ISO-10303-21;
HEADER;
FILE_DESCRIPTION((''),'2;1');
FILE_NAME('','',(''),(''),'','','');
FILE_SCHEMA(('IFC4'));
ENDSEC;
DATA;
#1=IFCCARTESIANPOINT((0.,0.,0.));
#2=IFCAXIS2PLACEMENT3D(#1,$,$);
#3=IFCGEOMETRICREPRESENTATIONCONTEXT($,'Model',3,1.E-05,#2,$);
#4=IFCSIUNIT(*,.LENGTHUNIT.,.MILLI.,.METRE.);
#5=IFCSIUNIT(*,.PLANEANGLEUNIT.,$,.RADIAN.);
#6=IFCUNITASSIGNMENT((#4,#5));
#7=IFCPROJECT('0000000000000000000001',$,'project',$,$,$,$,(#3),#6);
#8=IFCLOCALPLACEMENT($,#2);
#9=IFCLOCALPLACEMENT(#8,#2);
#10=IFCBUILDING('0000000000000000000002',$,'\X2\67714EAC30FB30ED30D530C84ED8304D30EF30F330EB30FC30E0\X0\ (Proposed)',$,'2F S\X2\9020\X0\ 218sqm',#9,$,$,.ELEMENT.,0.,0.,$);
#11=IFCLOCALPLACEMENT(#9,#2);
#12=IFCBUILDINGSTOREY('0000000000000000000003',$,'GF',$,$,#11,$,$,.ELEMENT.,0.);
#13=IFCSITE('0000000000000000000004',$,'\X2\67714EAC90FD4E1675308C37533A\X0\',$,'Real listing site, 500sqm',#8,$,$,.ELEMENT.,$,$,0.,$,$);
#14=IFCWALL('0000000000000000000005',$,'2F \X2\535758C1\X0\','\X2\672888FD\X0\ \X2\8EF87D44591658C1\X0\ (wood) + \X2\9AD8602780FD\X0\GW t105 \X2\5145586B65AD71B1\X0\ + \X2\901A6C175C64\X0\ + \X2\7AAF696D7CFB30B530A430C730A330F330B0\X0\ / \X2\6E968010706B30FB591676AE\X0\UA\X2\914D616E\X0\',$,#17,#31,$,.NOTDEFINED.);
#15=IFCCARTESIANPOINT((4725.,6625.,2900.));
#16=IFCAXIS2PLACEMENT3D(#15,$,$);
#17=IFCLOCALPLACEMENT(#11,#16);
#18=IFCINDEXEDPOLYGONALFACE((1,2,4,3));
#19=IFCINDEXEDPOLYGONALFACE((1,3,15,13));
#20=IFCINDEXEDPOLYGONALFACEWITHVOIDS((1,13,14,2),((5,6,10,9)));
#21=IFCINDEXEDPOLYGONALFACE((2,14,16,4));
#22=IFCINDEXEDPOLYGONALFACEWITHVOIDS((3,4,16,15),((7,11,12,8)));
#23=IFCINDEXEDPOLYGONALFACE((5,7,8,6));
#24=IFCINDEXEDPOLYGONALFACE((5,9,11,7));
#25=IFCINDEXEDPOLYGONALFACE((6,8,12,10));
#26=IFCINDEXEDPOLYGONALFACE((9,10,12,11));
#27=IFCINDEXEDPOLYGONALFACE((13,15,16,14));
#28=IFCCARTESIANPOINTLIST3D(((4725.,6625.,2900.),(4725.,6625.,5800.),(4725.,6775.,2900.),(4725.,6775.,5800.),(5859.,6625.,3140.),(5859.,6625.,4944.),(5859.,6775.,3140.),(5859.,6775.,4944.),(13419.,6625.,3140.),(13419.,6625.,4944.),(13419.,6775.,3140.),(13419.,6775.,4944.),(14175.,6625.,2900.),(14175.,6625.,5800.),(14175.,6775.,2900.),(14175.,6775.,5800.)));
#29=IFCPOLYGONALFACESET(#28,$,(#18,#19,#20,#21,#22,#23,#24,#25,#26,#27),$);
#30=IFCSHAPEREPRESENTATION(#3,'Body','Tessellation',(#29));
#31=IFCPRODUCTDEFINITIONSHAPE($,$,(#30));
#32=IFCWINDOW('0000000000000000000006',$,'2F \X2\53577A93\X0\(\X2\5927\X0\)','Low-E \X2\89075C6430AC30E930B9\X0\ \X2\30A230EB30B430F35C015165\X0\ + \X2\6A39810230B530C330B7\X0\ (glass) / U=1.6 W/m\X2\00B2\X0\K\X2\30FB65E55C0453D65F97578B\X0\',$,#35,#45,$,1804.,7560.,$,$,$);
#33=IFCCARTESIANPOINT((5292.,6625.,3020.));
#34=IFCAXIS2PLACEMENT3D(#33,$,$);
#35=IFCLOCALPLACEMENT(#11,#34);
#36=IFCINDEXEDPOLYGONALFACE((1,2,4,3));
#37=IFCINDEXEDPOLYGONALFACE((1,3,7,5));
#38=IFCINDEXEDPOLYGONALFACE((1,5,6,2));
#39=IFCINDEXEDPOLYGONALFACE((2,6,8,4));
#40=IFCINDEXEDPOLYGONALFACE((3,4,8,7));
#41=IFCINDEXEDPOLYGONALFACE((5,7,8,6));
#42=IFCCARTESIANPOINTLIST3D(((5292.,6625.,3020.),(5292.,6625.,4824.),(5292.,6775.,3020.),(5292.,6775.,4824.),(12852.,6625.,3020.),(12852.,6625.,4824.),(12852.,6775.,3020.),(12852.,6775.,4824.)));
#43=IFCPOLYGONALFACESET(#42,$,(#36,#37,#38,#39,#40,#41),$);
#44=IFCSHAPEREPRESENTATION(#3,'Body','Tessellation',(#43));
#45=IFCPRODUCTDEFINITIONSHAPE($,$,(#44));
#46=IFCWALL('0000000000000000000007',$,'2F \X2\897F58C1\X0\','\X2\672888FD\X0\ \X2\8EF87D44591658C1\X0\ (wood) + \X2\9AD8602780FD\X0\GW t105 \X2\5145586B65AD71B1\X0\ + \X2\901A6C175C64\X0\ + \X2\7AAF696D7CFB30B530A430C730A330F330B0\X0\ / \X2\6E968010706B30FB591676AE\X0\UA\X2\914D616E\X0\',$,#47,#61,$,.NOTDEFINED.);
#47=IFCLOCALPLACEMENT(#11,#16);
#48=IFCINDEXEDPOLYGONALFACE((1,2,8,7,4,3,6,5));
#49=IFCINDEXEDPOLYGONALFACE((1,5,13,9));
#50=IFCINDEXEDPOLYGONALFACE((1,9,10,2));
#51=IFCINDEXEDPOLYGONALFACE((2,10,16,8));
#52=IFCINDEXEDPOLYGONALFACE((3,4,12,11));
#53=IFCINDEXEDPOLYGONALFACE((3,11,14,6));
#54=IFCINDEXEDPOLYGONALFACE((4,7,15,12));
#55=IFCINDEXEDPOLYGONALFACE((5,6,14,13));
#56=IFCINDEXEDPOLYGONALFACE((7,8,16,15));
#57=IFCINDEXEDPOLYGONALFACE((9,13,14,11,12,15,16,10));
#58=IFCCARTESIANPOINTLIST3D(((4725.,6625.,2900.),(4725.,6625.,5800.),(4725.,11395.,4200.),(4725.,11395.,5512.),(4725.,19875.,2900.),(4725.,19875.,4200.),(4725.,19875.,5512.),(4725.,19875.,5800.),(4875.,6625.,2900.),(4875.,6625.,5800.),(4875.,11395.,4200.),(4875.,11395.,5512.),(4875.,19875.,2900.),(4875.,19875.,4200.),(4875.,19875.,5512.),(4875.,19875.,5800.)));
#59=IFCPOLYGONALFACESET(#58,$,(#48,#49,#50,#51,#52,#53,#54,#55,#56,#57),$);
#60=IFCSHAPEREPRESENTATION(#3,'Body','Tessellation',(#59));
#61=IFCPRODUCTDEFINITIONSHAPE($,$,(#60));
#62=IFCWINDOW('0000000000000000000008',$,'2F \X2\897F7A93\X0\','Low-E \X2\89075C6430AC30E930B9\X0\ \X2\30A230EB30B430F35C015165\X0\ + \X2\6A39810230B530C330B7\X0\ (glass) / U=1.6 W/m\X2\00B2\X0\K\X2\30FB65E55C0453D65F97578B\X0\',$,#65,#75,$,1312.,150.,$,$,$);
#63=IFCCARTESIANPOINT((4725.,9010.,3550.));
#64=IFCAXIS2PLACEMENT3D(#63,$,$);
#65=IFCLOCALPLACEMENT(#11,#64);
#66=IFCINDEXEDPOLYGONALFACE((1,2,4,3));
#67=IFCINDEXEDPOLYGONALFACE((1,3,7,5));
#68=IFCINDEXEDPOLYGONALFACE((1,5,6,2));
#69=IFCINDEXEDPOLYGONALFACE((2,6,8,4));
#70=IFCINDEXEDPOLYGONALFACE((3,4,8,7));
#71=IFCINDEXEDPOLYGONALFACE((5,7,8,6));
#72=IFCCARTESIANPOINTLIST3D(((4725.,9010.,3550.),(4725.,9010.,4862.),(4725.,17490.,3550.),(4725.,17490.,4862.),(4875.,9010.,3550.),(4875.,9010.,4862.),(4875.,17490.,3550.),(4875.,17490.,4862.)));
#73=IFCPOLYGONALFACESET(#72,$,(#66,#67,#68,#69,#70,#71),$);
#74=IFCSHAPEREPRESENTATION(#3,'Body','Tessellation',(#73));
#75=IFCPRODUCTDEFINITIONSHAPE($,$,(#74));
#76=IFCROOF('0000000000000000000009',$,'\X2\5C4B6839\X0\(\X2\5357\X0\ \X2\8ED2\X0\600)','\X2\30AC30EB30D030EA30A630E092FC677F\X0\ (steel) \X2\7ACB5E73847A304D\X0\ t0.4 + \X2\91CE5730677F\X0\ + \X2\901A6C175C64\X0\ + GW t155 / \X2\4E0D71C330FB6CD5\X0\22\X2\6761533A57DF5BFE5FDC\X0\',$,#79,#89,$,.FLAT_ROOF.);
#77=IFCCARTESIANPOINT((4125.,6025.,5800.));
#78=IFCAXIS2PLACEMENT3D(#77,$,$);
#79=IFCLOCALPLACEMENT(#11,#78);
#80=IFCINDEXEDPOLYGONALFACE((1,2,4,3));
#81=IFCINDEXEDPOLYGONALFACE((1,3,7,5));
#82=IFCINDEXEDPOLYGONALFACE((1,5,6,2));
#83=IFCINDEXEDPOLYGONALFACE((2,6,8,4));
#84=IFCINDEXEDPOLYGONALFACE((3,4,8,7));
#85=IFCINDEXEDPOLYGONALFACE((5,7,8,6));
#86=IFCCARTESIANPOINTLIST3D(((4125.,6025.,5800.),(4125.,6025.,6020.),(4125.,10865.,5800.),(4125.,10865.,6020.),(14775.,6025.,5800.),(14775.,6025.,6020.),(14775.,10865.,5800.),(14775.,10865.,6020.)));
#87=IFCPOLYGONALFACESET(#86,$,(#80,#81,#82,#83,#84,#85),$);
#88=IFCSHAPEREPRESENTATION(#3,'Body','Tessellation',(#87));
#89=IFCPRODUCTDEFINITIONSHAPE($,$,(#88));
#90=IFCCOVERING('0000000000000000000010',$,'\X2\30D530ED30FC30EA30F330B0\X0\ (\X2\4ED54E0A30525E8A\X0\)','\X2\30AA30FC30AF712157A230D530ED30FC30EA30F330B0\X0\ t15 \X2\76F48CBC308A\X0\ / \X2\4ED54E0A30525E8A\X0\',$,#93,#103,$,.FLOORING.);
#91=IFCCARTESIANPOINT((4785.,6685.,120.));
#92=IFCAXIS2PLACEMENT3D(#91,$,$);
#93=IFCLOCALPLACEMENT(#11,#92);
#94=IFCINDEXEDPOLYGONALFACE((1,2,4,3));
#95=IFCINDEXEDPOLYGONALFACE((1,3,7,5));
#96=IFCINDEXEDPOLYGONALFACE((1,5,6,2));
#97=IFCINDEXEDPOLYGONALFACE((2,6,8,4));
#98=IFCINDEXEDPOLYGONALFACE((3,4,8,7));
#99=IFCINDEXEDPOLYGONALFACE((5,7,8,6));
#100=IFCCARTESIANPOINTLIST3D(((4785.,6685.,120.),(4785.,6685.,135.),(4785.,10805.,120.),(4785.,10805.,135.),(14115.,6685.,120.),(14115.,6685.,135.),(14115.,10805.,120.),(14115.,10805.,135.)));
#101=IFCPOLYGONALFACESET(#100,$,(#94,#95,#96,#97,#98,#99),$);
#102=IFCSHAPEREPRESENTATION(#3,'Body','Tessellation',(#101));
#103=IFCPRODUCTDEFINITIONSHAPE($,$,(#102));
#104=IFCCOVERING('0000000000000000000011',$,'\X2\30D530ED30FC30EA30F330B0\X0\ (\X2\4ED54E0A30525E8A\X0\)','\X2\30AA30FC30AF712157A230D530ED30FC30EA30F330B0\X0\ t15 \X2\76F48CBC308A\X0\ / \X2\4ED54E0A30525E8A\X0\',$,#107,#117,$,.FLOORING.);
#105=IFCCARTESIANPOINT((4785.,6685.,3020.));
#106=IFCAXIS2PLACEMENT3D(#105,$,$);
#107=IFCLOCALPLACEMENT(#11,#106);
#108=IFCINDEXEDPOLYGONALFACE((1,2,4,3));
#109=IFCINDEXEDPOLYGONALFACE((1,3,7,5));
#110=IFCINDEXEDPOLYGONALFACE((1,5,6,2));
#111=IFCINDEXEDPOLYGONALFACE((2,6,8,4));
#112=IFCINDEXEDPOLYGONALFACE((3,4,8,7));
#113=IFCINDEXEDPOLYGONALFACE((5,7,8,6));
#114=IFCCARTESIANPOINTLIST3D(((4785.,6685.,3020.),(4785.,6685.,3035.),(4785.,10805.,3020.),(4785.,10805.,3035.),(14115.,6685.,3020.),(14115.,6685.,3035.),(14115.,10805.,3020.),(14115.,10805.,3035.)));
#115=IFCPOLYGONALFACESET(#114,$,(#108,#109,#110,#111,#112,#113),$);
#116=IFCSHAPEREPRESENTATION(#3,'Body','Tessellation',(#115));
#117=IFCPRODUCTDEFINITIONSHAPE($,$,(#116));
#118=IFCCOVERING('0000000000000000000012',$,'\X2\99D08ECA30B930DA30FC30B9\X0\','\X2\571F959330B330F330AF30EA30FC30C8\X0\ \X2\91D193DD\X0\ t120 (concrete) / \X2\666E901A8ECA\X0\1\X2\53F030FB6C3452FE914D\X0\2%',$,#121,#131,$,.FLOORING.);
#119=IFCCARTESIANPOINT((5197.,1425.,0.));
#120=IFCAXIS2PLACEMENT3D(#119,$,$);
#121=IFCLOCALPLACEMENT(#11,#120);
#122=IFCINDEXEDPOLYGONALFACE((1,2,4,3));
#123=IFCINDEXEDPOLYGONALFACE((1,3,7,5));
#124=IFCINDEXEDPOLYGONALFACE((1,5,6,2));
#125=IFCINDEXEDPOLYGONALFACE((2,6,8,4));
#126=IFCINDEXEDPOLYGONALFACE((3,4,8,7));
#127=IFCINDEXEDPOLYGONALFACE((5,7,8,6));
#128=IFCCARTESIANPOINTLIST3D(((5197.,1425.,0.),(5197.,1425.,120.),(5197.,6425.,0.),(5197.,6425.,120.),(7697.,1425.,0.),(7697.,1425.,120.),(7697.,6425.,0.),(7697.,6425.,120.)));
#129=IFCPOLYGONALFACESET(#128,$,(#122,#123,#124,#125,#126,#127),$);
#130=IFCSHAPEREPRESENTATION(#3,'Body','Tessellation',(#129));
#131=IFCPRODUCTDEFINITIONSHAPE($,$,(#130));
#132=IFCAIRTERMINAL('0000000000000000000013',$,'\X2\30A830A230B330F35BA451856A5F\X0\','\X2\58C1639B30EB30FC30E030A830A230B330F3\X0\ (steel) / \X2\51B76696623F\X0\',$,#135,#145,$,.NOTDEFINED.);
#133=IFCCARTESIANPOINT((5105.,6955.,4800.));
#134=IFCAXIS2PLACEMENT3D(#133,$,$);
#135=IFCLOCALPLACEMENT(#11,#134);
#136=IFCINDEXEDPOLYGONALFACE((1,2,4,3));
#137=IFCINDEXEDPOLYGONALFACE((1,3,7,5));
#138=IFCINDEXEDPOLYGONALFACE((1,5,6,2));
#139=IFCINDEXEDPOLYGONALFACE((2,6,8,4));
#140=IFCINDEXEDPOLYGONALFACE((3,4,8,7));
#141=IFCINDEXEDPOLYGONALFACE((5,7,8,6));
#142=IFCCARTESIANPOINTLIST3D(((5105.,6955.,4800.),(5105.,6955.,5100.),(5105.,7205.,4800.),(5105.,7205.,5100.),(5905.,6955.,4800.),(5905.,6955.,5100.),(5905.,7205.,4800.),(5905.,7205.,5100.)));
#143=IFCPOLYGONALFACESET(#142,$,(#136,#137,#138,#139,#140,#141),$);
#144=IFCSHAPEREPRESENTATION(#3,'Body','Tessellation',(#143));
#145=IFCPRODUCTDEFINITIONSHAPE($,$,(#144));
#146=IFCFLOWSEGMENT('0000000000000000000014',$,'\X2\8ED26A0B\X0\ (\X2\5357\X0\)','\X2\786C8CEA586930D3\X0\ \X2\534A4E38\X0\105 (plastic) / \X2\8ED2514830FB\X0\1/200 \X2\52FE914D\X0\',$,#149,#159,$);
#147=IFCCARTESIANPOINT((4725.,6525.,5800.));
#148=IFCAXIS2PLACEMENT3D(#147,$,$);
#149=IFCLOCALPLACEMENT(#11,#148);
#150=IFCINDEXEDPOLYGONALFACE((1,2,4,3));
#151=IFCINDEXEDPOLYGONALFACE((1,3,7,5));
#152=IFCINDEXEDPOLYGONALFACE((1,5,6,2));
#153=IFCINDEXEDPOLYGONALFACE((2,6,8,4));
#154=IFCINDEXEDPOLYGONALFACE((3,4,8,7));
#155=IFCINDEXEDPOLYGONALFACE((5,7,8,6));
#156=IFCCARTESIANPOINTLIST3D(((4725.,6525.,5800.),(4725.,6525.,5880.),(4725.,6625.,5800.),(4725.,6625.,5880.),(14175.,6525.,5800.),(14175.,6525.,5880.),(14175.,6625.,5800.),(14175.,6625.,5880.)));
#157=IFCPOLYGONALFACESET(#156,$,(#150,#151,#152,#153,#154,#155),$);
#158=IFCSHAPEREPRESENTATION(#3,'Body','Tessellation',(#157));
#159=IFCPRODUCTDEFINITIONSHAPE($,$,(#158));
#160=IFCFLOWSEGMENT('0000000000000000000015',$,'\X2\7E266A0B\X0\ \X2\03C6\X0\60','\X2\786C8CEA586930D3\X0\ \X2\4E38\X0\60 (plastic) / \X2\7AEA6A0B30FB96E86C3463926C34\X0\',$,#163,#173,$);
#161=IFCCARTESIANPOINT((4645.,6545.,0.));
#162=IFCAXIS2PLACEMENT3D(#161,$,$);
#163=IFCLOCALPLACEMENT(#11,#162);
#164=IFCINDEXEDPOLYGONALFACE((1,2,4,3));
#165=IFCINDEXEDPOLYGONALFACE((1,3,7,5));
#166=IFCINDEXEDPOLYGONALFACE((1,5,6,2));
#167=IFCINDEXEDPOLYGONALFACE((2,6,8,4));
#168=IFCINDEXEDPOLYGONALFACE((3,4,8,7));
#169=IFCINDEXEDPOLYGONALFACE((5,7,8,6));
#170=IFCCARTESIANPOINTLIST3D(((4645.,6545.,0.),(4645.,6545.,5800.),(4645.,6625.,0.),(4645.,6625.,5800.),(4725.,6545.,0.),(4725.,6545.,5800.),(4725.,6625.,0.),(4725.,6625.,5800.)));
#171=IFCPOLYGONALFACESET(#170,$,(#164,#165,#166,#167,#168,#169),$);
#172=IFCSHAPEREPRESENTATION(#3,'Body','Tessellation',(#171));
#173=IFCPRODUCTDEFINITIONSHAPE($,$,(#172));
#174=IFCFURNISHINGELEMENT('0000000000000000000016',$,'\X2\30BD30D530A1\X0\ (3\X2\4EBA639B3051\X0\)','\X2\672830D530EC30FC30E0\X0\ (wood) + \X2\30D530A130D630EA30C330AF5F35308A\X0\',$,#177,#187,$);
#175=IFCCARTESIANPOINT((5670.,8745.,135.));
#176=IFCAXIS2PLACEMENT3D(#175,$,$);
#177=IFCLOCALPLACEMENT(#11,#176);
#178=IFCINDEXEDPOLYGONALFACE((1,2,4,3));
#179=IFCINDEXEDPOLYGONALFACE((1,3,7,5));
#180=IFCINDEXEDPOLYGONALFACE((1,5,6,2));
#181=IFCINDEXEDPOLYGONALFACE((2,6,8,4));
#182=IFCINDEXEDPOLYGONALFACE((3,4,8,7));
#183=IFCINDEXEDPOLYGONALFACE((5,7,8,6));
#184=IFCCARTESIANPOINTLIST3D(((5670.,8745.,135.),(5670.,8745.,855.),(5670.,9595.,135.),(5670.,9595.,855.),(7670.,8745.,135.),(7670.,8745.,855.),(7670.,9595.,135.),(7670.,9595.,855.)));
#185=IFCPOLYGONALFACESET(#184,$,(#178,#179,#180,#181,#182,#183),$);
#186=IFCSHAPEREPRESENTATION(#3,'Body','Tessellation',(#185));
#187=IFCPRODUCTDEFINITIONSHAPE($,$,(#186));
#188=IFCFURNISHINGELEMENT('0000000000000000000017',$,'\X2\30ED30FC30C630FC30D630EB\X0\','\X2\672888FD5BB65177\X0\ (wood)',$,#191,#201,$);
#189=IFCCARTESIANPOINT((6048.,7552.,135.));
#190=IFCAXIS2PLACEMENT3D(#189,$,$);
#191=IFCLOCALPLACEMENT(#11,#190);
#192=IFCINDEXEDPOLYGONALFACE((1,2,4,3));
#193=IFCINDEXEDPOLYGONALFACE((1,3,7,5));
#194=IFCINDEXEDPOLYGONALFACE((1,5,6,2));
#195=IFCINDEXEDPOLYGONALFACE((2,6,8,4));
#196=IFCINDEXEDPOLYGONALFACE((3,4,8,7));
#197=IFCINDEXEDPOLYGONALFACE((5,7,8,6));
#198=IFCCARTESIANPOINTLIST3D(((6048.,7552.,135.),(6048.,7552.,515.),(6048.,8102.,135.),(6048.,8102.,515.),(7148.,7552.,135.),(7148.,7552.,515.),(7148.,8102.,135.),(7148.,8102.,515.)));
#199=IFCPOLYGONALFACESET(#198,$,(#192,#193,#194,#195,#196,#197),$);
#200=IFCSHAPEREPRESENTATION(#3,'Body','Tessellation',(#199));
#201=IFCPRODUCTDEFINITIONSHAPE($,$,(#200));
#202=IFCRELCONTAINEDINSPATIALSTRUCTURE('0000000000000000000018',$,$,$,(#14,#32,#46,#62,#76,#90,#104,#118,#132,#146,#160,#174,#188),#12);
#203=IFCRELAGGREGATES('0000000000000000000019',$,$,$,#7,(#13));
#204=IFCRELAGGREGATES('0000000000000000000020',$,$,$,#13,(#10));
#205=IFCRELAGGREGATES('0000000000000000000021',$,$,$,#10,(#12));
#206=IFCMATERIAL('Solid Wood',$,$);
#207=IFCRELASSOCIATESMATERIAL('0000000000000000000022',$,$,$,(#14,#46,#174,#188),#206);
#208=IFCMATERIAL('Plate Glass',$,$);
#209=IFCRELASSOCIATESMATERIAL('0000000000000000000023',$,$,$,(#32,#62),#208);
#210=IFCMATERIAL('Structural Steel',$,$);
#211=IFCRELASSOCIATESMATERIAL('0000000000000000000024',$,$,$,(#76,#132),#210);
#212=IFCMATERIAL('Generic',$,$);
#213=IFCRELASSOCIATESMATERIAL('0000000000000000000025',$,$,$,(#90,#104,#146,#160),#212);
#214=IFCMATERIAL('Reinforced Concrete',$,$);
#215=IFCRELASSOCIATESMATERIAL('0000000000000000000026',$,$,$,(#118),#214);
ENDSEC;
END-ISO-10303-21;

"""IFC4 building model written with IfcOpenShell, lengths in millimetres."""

from ifc_helpers import new_model, si_unit, frame, frame_2d, origin, place, context, project, spatial, rectangle, extrude, material, element, fill, save


model = new_model("IFC4")

# Units and contexts
model_context = context("Model", 3, precision=1e-05, world=origin())
ifc_project = project(units=[si_unit("LENGTHUNIT", "METRE", prefix="MILLI"), si_unit("PLANEANGLEUNIT", "RADIAN")], contexts=[model_context])

# Site, building, storey
site_placement = place(None, origin())
site = spatial("IfcSite", under=ifc_project, at=site_placement, Name="東京都世田谷区", ObjectType="Real listing site, 500sqm", CompositionType="ELEMENT", RefElevation=0.0)
building_placement = place(site_placement, origin())
building = spatial("IfcBuilding", under=site, at=building_placement, Name="東京・ロフト付きワンルーム (Proposed)", ObjectType="2F S造 218sqm", CompositionType="ELEMENT", ElevationOfRefHeight=0.0, ElevationOfTerrain=0.0)
storey_placement = place(building_placement, origin())
storey = spatial("IfcBuildingStorey", under=building, at=storey_placement, Name="GF", CompositionType="ELEMENT", Elevation=0.0)

# Shared definitions
ifc_material_1 = material(Name="Solid Wood")

# Shared definitions
ifc_material_2 = material(Name="Reinforced Concrete")

# Shared definitions
ifc_material_3 = material(Name="Plate Glass")

# Walls, openings, windows
wall_1_placement = place(storey_placement, frame((4725.0, 6625.0, 2900.0)))
wall_1 = element("IfcWall", 1, at=wall_1_placement, inside=storey, material=ifc_material_1, Name="2F 南壁", Description="木製 軸組外壁 (wood) + 高性能GW t105 充填断熱 + 通気層 + 窯業系サイディング / 準耐火・外皮UA配慮", PredefinedType="NOTDEFINED", context=model_context, shape_type="SweptSolid", body=[
    extrude(rectangle(XDim=9450.0, YDim=150.0, at=frame_2d((4725.0, 75.0))), frame((4725.0, 6625.0, 2900.0)), (0.0, 0.0, 1.0), 2900.0),
])
opening_1_placement = place(storey_placement, frame((5292.0, 6625.0, 3020.0)))
opening_1 = element("IfcOpeningElement", 2, at=opening_1_placement, cuts=wall_1, PredefinedType="NOTDEFINED", context=model_context, shape_type="SweptSolid", body=[
    extrude(rectangle(XDim=7560.0, YDim=150.0, at=frame_2d((3780.0, 75.0))), frame((5292.0, 6625.0, 3020.0)), (0.0, 0.0, 1.0), 1804.0),
])
window_1_placement = place(storey_placement, frame((5292.0, 6625.0, 3020.0)))
window_1 = element("IfcWindow", 3, at=window_1_placement, inside=storey, material=ifc_material_3, Name="2F 南窓(大)", Description="Low-E 複層ガラス アルゴン封入 + 樹脂サッシ (glass) / U=1.6 W/m²K・日射取得型", OverallHeight=1804.0, OverallWidth=7560.0, context=model_context, shape_type="SweptSolid", body=[
    extrude(rectangle(XDim=7560.0, YDim=150.0, at=frame_2d((3780.0, 75.0))), frame((5292.0, 6625.0, 3020.0)), (0.0, 0.0, 1.0), 1804.0),
])
fill(opening_1, window_1)
wall_2_placement = place(storey_placement, frame((4725.0, 6625.0, 2900.0)))
wall_2 = element("IfcWall", 4, at=wall_2_placement, inside=storey, material=ifc_material_1, Name="2F 西壁", Description="木製 軸組外壁 (wood) + 高性能GW t105 充填断熱 + 通気層 + 窯業系サイディング / 準耐火・外皮UA配慮", PredefinedType="NOTDEFINED", context=model_context, shape_type="SweptSolid", body=[
    extrude(rectangle(XDim=150.0, YDim=13250.0, at=frame_2d((75.0, 6625.0))), frame((4725.0, 6625.0, 2900.0)), (0.0, 0.0, 1.0), 2900.0),
])
opening_2_placement = place(storey_placement, frame((4725.0, 9010.0, 3550.0)))
opening_2 = element("IfcOpeningElement", 5, at=opening_2_placement, cuts=wall_2, PredefinedType="NOTDEFINED", context=model_context, shape_type="SweptSolid", body=[
    extrude(rectangle(XDim=150.0, YDim=8480.0, at=frame_2d((75.0, 4240.0))), frame((4725.0, 9010.0, 3550.0)), (0.0, 0.0, 1.0), 1312.0),
])
window_2_placement = place(storey_placement, frame((4725.0, 9010.0, 3550.0)))
window_2 = element("IfcWindow", 6, at=window_2_placement, inside=storey, material=ifc_material_3, Name="2F 西窓", Description="Low-E 複層ガラス アルゴン封入 + 樹脂サッシ (glass) / U=1.6 W/m²K・日射取得型", OverallHeight=1312.0, OverallWidth=150.0, context=model_context, shape_type="SweptSolid", body=[
    extrude(rectangle(XDim=150.0, YDim=8480.0, at=frame_2d((75.0, 4240.0))), frame((4725.0, 9010.0, 3550.0)), (0.0, 0.0, 1.0), 1312.0),
])
fill(opening_2, window_2)

# Roof
ifc_material_4 = material(Name="Structural Steel")
for number, where, name in (
    (7, (4125.0, 6025.0, 5800.0), "屋根(南 軒600)"),
):
    element("IfcRoof", number, at=place(storey_placement, frame(where)), inside=storey, material=ifc_material_4, Name=name, Description="ガルバリウム鋼板 (steel) 立平葺き t0.4 + 野地板 + 通気層 + GW t155 / 不燃・法22条区域対応", PredefinedType="FLAT_ROOF", context=model_context, shape_type="SweptSolid", body=[
        extrude(rectangle(XDim=10650.0, YDim=4840.0, at=frame_2d((5325.0, 2420.0))), frame((4125.0, 6025.0, 5800.0)), (0.0, 0.0, 1.0), 220.0),
    ])

# Coverings
ifc_material_5 = material(Name="Generic")
covering_1_placement = place(storey_placement, frame((4785.0, 6685.0, 120.0)))
element("IfcCovering", 8, at=covering_1_placement, inside=storey, material=ifc_material_5, Name="フローリング (仕上げ床)", Description="オーク無垢フローリング t15 直貼り / 仕上げ床", PredefinedType="FLOORING", context=model_context, shape_type="SweptSolid", body=[
    extrude(rectangle(XDim=9330.0, YDim=4120.0, at=frame_2d((4665.0, 2060.0))), frame((4785.0, 6685.0, 120.0)), (0.0, 0.0, 1.0), 15.0),
])
covering_2_placement = place(storey_placement, frame((4785.0, 6685.0, 3020.0)))
element("IfcCovering", 9, at=covering_2_placement, inside=storey, material=ifc_material_5, Name="フローリング (仕上げ床)", Description="オーク無垢フローリング t15 直貼り / 仕上げ床", PredefinedType="FLOORING", context=model_context, shape_type="SweptSolid", body=[
    extrude(rectangle(XDim=9330.0, YDim=4120.0, at=frame_2d((4665.0, 2060.0))), frame((4785.0, 6685.0, 3020.0)), (0.0, 0.0, 1.0), 15.0),
])
covering_3_placement = place(storey_placement, frame((5197.0, 1425.0, 0.0)))
element("IfcCovering", 10, at=covering_3_placement, inside=storey, material=ifc_material_2, Name="駐車スペース", Description="土間コンクリート 金鏝 t120 (concrete) / 普通車1台・水勾配2%", PredefinedType="FLOORING", context=model_context, shape_type="SweptSolid", body=[
    extrude(rectangle(XDim=2500.0, YDim=5000.0, at=frame_2d((1250.0, 2500.0))), frame((5197.0, 1425.0, 0.0)), (0.0, 0.0, 1.0), 120.0),
])

# Air terminal
air_terminal_placement = place(storey_placement, frame((5105.0, 6955.0, 4800.0)))
element("IfcAirTerminal", 11, at=air_terminal_placement, inside=storey, material=ifc_material_4, Name="エアコン室内機", Description="壁掛ルームエアコン (steel) / 冷暖房", PredefinedType="NOTDEFINED", context=model_context, shape_type="SweptSolid", body=[
    extrude(rectangle(XDim=800.0, YDim=250.0, at=frame_2d((400.0, 125.0))), frame((5105.0, 6955.0, 4800.0)), (0.0, 0.0, 1.0), 300.0),
])

# Flow segments
flow_segment_1_placement = place(storey_placement, frame((4725.0, 6525.0, 5800.0)))
element("IfcFlowSegment", 12, at=flow_segment_1_placement, inside=storey, material=ifc_material_5, Name="軒樋 (南)", Description="硬質塩ビ 半丸105 (plastic) / 軒先・1/200 勾配", context=model_context, shape_type="SweptSolid", body=[
    extrude(rectangle(XDim=9450.0, YDim=100.0, at=frame_2d((4725.0, 50.0))), frame((4725.0, 6525.0, 5800.0)), (0.0, 0.0, 1.0), 80.0),
])
flow_segment_2_placement = place(storey_placement, frame((4645.0, 6545.0, 0.0)))
element("IfcFlowSegment", 13, at=flow_segment_2_placement, inside=storey, material=ifc_material_5, Name="縦樋 φ60", Description="硬質塩ビ 丸60 (plastic) / 竪樋・雨水排水", context=model_context, shape_type="SweptSolid", body=[
    extrude(rectangle(XDim=80.0, YDim=80.0, at=frame_2d((40.0, 40.0))), frame((4645.0, 6545.0, 0.0)), (0.0, 0.0, 1.0), 5800.0),
])

# Furnishing elements
furnishing_1_placement = place(storey_placement, frame((5670.0, 8745.0, 135.0)))
element("IfcFurnishingElement", 14, at=furnishing_1_placement, inside=storey, material=ifc_material_1, Name="ソファ (3人掛け)", Description="木フレーム (wood) + ファブリック張り", context=model_context, shape_type="SweptSolid", body=[
    extrude(rectangle(XDim=2000.0, YDim=850.0, at=frame_2d((1000.0, 425.0))), frame((5670.0, 8745.0, 135.0)), (0.0, 0.0, 1.0), 720.0),
])
furnishing_2_placement = place(storey_placement, frame((6048.0, 7552.0, 135.0)))
element("IfcFurnishingElement", 15, at=furnishing_2_placement, inside=storey, material=ifc_material_1, Name="ローテーブル", Description="木製家具 (wood)", context=model_context, shape_type="SweptSolid", body=[
    extrude(rectangle(XDim=1100.0, YDim=550.0, at=frame_2d((550.0, 275.0))), frame((6048.0, 7552.0, 135.0)), (0.0, 0.0, 1.0), 380.0),
])

save(model, "model.ifc")
